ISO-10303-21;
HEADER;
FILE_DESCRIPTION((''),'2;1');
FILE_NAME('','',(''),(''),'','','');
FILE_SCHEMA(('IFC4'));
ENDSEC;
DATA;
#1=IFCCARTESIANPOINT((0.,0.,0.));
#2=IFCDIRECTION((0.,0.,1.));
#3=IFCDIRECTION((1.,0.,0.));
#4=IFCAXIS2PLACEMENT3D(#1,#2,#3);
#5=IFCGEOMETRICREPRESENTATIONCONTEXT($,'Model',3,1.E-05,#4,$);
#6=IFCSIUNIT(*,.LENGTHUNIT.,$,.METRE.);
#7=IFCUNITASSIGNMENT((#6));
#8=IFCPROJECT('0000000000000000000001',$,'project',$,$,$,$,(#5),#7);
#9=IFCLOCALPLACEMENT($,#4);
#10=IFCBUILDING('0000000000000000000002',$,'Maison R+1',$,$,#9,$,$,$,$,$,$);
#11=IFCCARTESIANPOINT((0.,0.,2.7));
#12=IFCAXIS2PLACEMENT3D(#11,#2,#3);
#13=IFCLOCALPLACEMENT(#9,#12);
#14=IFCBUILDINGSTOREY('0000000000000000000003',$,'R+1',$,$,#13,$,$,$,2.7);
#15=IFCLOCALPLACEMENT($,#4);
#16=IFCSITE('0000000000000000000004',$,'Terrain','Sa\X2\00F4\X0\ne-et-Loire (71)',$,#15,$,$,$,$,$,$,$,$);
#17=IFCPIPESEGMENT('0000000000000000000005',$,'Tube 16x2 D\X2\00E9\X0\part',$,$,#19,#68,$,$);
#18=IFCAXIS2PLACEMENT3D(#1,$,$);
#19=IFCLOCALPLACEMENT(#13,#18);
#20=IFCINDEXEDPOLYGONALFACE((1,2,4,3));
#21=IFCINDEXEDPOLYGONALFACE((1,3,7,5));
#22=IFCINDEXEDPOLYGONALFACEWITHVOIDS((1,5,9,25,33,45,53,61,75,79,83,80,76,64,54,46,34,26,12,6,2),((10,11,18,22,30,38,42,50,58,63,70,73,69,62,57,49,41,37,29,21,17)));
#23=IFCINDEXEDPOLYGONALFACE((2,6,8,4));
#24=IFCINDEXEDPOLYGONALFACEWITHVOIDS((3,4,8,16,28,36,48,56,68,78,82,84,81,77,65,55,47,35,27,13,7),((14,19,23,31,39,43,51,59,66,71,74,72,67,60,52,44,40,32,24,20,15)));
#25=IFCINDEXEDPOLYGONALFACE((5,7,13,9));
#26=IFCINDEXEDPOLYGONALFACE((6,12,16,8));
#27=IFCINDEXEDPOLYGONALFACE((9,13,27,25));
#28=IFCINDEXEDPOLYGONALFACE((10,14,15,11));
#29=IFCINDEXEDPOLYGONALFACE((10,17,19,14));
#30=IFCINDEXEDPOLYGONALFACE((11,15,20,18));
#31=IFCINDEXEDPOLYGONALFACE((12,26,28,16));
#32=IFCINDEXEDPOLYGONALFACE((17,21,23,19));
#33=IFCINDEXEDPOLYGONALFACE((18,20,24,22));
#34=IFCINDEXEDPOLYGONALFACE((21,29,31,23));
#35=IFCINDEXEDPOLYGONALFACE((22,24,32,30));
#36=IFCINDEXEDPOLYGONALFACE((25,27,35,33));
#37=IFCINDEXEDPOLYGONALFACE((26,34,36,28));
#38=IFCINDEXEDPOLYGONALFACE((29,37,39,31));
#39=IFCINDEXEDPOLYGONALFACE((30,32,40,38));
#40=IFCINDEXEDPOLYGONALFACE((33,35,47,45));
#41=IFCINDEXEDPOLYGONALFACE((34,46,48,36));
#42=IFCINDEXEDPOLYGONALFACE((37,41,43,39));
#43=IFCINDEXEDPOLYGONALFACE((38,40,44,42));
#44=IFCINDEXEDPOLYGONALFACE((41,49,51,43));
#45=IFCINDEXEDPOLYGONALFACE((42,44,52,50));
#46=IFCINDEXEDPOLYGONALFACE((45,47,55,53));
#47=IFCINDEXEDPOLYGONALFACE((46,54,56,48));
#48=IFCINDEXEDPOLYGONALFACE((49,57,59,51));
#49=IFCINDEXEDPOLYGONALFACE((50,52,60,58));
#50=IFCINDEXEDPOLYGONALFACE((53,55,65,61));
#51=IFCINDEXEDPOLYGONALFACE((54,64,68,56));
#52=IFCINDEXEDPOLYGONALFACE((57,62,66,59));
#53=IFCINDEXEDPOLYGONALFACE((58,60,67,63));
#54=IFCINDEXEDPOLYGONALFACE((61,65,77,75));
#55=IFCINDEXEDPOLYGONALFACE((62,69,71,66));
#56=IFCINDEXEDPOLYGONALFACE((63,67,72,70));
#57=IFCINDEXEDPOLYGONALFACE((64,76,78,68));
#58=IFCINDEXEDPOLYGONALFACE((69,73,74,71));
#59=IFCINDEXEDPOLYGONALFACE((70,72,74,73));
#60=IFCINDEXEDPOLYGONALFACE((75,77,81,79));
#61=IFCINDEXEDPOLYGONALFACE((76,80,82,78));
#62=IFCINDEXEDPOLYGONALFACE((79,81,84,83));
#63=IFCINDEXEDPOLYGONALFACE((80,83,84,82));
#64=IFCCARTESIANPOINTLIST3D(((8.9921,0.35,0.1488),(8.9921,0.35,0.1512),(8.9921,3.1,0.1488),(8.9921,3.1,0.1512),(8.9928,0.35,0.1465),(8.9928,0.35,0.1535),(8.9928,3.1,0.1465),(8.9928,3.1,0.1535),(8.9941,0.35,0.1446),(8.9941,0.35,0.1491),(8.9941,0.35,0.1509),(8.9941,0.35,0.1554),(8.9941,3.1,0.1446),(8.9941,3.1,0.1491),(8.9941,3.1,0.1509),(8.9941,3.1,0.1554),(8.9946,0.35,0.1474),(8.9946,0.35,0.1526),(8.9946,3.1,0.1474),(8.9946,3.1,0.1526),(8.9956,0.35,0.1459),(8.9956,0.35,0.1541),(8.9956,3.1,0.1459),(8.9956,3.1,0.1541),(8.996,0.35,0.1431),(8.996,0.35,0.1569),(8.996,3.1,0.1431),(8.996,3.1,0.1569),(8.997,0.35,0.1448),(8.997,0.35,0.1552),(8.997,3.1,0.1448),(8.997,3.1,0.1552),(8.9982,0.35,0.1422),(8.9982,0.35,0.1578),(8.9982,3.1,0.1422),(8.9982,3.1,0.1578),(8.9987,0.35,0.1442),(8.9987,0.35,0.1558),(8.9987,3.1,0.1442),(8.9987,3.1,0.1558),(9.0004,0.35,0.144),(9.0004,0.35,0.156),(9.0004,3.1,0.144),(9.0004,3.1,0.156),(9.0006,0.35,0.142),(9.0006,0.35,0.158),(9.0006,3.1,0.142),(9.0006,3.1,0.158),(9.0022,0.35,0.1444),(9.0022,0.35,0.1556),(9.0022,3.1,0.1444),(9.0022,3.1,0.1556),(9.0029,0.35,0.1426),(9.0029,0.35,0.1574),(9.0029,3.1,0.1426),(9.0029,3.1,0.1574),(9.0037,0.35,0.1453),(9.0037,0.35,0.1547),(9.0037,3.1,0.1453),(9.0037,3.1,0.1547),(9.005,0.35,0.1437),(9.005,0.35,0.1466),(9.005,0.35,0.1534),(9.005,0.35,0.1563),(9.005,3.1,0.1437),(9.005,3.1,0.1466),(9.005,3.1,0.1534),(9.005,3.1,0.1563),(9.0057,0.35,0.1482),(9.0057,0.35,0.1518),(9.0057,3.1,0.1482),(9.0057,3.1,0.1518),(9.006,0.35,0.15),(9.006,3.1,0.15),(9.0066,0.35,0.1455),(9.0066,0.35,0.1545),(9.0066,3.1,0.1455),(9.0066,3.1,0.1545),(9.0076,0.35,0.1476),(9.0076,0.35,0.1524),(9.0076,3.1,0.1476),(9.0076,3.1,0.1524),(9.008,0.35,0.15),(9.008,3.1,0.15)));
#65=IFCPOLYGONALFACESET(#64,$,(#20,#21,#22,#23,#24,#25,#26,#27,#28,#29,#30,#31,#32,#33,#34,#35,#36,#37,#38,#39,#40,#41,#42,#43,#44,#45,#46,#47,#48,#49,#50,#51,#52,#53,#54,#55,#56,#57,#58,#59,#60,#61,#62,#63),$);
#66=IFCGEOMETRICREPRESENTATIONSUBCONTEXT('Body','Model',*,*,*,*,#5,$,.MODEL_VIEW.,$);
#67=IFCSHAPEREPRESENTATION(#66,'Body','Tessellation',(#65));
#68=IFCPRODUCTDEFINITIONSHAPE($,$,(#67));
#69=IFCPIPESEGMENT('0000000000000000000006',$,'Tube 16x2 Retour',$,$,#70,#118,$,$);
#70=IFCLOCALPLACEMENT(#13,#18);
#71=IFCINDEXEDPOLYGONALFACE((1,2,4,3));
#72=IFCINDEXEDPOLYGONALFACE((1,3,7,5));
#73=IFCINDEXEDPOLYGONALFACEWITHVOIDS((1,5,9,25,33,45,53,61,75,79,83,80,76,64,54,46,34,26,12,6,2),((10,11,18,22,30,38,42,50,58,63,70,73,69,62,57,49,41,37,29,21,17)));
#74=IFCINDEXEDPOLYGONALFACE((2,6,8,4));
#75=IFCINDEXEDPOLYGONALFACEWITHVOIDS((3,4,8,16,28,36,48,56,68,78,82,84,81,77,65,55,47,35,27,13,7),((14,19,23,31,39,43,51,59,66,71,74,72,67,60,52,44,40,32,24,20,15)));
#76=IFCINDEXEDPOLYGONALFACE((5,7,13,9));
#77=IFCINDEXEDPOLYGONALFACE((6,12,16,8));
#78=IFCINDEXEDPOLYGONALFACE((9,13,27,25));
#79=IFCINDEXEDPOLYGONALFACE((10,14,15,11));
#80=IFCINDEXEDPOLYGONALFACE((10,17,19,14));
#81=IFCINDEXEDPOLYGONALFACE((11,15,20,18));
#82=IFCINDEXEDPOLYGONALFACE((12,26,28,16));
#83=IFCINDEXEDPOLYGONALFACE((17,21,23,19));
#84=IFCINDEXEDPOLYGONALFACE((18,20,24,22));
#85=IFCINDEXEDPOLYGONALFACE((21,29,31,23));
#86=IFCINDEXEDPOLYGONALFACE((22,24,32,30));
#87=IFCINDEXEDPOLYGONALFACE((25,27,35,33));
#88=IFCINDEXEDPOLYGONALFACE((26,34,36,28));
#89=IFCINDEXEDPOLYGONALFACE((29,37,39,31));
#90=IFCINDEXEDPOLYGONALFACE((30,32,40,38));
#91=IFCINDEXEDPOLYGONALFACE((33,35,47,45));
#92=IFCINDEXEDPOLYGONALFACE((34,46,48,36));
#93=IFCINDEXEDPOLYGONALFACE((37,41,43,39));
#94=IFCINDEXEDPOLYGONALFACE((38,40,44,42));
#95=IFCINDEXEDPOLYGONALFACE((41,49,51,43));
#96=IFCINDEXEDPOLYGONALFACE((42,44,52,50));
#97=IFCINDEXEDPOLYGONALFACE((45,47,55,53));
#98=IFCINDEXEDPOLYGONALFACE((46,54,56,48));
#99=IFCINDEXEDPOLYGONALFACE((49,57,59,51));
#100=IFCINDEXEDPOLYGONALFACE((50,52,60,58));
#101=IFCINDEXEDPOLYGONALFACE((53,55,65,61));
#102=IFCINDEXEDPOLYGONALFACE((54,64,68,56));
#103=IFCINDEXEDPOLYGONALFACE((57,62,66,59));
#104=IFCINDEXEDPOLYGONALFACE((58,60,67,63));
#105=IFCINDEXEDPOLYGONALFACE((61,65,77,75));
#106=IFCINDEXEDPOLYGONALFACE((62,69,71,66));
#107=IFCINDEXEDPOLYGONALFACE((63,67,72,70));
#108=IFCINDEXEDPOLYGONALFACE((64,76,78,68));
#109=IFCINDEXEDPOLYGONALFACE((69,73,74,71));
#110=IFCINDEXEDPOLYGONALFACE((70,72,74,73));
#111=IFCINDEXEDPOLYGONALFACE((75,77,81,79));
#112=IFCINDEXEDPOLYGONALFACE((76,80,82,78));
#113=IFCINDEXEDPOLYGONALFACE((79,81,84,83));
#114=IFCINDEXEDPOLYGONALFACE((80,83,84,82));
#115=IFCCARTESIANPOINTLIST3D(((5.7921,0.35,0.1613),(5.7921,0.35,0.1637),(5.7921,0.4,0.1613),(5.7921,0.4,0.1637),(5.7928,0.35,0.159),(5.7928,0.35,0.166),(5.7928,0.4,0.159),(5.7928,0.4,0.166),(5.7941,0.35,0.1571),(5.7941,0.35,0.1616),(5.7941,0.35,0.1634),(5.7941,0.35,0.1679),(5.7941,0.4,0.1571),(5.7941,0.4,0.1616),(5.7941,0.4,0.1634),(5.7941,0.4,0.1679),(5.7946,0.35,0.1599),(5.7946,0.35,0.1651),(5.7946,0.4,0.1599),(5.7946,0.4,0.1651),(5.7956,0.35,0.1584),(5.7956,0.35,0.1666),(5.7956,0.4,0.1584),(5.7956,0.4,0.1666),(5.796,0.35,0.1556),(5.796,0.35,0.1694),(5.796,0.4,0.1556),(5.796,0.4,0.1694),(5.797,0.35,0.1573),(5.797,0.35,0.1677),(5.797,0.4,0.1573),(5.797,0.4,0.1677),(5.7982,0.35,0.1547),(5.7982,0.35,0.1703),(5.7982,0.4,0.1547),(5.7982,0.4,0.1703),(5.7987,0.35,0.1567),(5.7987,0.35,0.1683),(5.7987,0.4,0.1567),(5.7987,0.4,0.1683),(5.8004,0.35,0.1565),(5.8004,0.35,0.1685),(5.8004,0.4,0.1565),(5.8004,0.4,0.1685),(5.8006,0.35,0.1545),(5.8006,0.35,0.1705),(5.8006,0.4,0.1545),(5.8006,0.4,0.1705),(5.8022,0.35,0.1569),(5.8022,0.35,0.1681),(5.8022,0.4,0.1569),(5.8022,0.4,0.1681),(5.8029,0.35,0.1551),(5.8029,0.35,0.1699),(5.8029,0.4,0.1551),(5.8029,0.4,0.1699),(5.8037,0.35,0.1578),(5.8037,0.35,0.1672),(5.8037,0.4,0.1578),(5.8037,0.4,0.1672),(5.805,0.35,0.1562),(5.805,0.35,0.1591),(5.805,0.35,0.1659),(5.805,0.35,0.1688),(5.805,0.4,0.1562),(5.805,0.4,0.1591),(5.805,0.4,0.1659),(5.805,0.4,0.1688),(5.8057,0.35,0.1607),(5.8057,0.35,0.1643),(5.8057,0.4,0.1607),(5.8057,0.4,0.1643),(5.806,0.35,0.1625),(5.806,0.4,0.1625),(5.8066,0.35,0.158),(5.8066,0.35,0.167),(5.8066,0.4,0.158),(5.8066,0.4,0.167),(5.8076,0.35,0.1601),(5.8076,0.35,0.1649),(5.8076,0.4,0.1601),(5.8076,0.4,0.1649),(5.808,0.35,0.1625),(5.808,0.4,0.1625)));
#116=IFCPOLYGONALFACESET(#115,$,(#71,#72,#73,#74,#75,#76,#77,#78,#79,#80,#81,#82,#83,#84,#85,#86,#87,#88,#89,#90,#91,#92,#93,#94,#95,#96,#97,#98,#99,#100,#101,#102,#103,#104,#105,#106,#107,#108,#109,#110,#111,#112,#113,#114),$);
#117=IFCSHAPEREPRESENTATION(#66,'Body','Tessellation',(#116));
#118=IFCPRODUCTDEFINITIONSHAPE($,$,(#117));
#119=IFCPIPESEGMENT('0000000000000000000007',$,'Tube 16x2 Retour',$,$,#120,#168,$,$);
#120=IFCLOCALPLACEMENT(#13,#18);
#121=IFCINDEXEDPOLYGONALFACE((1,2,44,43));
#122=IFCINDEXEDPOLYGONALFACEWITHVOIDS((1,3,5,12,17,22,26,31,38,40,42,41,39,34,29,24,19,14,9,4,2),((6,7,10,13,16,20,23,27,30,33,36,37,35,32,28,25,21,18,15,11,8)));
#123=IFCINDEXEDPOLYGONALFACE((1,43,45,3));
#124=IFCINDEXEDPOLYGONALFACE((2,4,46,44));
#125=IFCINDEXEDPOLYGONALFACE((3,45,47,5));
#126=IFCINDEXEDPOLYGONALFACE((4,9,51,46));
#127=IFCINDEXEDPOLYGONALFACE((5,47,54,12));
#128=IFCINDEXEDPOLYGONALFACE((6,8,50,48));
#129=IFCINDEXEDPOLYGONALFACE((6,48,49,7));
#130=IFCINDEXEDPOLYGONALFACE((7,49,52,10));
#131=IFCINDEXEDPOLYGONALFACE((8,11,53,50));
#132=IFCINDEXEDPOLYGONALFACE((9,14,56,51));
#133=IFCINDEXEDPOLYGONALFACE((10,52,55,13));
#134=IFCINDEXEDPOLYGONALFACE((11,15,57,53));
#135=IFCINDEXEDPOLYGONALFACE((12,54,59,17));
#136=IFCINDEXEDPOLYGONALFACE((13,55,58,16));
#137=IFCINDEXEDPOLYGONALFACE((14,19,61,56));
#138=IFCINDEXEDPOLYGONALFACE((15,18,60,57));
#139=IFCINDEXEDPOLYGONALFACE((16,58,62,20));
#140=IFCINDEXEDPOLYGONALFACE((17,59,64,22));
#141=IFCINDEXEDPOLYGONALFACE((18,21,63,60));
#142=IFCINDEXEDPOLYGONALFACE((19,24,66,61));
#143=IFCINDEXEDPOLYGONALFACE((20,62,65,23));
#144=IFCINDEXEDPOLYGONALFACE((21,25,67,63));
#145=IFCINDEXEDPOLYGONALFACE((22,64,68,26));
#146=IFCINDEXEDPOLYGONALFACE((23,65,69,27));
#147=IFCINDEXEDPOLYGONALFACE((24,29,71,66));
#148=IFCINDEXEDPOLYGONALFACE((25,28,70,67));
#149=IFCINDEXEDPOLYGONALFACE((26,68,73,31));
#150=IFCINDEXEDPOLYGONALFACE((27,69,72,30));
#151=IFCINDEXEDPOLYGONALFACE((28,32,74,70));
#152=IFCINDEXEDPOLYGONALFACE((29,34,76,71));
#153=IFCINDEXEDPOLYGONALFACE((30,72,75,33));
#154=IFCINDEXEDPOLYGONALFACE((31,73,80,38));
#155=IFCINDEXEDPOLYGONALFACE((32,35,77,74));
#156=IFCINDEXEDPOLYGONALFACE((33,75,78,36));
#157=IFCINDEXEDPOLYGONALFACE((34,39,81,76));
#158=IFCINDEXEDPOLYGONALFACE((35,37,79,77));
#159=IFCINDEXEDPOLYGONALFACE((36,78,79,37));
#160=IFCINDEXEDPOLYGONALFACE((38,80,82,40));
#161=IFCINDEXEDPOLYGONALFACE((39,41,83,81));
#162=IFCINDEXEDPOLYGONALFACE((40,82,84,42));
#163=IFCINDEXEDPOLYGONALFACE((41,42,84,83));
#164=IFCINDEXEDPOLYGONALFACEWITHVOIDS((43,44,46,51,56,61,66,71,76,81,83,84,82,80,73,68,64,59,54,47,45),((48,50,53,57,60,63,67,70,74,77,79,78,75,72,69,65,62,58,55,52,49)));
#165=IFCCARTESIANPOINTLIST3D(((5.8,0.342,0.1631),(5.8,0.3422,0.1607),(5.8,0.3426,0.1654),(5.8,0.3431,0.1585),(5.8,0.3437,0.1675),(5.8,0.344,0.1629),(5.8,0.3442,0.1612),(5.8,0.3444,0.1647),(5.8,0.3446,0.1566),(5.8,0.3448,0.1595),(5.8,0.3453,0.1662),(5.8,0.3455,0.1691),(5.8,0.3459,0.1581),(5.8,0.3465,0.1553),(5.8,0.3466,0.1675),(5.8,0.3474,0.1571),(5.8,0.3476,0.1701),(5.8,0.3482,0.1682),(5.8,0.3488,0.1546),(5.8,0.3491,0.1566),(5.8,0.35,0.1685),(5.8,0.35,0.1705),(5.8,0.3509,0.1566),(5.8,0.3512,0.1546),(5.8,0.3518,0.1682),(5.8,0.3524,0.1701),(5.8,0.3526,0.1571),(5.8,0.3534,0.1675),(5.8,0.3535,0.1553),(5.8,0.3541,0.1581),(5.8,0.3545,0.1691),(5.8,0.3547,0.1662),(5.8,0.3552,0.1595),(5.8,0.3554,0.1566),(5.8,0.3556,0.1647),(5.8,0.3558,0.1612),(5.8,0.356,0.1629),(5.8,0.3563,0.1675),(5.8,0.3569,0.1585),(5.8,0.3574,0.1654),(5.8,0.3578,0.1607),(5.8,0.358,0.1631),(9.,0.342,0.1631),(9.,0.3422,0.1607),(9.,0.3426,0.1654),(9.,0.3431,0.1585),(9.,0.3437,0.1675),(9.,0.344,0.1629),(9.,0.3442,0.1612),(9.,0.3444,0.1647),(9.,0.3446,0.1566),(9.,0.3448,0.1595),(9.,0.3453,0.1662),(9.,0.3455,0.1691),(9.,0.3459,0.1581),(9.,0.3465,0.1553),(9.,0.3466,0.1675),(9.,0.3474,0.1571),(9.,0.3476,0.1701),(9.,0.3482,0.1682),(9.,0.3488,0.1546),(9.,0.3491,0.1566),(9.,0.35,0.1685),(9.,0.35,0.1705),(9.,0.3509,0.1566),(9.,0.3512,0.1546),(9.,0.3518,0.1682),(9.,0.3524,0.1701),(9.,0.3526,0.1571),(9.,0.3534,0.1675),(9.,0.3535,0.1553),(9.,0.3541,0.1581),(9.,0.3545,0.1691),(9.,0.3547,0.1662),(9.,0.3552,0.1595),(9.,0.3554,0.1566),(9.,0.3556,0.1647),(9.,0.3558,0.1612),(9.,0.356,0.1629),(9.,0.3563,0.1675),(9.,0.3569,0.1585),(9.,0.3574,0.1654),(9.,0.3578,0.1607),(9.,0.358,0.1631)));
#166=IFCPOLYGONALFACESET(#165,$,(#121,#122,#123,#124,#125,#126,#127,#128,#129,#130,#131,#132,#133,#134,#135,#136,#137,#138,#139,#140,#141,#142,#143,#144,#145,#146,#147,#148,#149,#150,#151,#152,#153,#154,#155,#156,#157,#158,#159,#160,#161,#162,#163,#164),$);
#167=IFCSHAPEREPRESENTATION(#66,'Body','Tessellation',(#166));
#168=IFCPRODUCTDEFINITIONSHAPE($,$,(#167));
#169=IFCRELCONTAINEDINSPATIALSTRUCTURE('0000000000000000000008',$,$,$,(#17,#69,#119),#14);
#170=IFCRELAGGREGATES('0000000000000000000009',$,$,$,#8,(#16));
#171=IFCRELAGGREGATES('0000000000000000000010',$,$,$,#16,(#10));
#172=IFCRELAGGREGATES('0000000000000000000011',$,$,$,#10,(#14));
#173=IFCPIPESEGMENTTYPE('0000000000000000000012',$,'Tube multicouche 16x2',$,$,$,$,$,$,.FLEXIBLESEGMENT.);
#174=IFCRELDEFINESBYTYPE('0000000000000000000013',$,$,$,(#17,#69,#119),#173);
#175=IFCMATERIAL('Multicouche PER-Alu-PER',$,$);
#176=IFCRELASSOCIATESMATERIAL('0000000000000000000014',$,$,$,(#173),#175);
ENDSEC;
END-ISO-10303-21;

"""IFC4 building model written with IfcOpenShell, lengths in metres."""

from ifc_helpers import new_model, si_unit, frame, origin_with_axes, place, context, subcontext, project, spatial, hollow_circle, extrude, material, type_object, element, save


model = new_model("IFC4")

# Units and contexts
model_context = context("Model", 3, precision=1e-05, world=origin_with_axes())
body_context = subcontext(model_context, "Body", "Model", "MODEL_VIEW")
ifc_project = project(units=[si_unit("LENGTHUNIT", "METRE")], contexts=[model_context])

# Site, building, storey
site_placement = place(None, origin_with_axes())
site = spatial("IfcSite", under=ifc_project, at=site_placement, Name="Terrain", Description="Saône-et-Loire (71)")
building_placement = place(None, origin_with_axes())
building = spatial("IfcBuilding", under=site, at=building_placement, Name="Maison R+1")
storey_placement = place(building_placement, frame((0.0, 0.0, 2.7), z_axis=(0.0, 0.0, 1.0), x_axis=(1.0, 0.0, 0.0)))
storey = spatial("IfcBuildingStorey", under=building, at=storey_placement, Name="R+1", Elevation=2.7)

# Pipe segments
ifc_material_1 = material(Name="Multicouche PER-Alu-PER")
pipe_segment_type_1 = type_object("IfcPipeSegmentType", Name="Tube multicouche 16x2", PredefinedType="FLEXIBLESEGMENT", material=ifc_material_1)
pipe_segment_1_placement = place(storey_placement, frame((9.0, 0.35, 0.15), z_axis=(0.0, 1.0, 0.0), x_axis=(1.0, 0.0, 0.0)))
element("IfcPipeSegment", 1, at=pipe_segment_1_placement, inside=storey, type_object=pipe_segment_type_1, Name="Tube 16x2 Départ", context=body_context, shape_type="SweptSolid", body=[
    extrude(hollow_circle(Radius=0.008, WallThickness=0.002), origin_with_axes(), (0.0, 0.0, 1.0), 2.75),
])
pipe_segment_2_placement = place(storey_placement, frame((5.8, 0.4, 0.1625), z_axis=(0.0, -1.0, 0.0), x_axis=(1.0, 0.0, 0.0)))
element("IfcPipeSegment", 2, at=pipe_segment_2_placement, inside=storey, type_object=pipe_segment_type_1, Name="Tube 16x2 Retour", context=body_context, shape_type="SweptSolid", body=[
    extrude(hollow_circle(Radius=0.008, WallThickness=0.002), origin_with_axes(), (0.0, 0.0, 1.0), 0.05),
])
pipe_segment_3_placement = place(storey_placement, frame((5.8, 0.35, 0.1625), z_axis=(1.0, 0.0, 0.0), x_axis=(0.0, 0.0, 1.0)))
element("IfcPipeSegment", 3, at=pipe_segment_3_placement, inside=storey, type_object=pipe_segment_type_1, Name="Tube 16x2 Retour", context=body_context, shape_type="SweptSolid", body=[
    extrude(hollow_circle(Radius=0.008, WallThickness=0.002), origin_with_axes(), (0.0, 0.0, 1.0), 3.2),
])

save(model, "model.ifc")
